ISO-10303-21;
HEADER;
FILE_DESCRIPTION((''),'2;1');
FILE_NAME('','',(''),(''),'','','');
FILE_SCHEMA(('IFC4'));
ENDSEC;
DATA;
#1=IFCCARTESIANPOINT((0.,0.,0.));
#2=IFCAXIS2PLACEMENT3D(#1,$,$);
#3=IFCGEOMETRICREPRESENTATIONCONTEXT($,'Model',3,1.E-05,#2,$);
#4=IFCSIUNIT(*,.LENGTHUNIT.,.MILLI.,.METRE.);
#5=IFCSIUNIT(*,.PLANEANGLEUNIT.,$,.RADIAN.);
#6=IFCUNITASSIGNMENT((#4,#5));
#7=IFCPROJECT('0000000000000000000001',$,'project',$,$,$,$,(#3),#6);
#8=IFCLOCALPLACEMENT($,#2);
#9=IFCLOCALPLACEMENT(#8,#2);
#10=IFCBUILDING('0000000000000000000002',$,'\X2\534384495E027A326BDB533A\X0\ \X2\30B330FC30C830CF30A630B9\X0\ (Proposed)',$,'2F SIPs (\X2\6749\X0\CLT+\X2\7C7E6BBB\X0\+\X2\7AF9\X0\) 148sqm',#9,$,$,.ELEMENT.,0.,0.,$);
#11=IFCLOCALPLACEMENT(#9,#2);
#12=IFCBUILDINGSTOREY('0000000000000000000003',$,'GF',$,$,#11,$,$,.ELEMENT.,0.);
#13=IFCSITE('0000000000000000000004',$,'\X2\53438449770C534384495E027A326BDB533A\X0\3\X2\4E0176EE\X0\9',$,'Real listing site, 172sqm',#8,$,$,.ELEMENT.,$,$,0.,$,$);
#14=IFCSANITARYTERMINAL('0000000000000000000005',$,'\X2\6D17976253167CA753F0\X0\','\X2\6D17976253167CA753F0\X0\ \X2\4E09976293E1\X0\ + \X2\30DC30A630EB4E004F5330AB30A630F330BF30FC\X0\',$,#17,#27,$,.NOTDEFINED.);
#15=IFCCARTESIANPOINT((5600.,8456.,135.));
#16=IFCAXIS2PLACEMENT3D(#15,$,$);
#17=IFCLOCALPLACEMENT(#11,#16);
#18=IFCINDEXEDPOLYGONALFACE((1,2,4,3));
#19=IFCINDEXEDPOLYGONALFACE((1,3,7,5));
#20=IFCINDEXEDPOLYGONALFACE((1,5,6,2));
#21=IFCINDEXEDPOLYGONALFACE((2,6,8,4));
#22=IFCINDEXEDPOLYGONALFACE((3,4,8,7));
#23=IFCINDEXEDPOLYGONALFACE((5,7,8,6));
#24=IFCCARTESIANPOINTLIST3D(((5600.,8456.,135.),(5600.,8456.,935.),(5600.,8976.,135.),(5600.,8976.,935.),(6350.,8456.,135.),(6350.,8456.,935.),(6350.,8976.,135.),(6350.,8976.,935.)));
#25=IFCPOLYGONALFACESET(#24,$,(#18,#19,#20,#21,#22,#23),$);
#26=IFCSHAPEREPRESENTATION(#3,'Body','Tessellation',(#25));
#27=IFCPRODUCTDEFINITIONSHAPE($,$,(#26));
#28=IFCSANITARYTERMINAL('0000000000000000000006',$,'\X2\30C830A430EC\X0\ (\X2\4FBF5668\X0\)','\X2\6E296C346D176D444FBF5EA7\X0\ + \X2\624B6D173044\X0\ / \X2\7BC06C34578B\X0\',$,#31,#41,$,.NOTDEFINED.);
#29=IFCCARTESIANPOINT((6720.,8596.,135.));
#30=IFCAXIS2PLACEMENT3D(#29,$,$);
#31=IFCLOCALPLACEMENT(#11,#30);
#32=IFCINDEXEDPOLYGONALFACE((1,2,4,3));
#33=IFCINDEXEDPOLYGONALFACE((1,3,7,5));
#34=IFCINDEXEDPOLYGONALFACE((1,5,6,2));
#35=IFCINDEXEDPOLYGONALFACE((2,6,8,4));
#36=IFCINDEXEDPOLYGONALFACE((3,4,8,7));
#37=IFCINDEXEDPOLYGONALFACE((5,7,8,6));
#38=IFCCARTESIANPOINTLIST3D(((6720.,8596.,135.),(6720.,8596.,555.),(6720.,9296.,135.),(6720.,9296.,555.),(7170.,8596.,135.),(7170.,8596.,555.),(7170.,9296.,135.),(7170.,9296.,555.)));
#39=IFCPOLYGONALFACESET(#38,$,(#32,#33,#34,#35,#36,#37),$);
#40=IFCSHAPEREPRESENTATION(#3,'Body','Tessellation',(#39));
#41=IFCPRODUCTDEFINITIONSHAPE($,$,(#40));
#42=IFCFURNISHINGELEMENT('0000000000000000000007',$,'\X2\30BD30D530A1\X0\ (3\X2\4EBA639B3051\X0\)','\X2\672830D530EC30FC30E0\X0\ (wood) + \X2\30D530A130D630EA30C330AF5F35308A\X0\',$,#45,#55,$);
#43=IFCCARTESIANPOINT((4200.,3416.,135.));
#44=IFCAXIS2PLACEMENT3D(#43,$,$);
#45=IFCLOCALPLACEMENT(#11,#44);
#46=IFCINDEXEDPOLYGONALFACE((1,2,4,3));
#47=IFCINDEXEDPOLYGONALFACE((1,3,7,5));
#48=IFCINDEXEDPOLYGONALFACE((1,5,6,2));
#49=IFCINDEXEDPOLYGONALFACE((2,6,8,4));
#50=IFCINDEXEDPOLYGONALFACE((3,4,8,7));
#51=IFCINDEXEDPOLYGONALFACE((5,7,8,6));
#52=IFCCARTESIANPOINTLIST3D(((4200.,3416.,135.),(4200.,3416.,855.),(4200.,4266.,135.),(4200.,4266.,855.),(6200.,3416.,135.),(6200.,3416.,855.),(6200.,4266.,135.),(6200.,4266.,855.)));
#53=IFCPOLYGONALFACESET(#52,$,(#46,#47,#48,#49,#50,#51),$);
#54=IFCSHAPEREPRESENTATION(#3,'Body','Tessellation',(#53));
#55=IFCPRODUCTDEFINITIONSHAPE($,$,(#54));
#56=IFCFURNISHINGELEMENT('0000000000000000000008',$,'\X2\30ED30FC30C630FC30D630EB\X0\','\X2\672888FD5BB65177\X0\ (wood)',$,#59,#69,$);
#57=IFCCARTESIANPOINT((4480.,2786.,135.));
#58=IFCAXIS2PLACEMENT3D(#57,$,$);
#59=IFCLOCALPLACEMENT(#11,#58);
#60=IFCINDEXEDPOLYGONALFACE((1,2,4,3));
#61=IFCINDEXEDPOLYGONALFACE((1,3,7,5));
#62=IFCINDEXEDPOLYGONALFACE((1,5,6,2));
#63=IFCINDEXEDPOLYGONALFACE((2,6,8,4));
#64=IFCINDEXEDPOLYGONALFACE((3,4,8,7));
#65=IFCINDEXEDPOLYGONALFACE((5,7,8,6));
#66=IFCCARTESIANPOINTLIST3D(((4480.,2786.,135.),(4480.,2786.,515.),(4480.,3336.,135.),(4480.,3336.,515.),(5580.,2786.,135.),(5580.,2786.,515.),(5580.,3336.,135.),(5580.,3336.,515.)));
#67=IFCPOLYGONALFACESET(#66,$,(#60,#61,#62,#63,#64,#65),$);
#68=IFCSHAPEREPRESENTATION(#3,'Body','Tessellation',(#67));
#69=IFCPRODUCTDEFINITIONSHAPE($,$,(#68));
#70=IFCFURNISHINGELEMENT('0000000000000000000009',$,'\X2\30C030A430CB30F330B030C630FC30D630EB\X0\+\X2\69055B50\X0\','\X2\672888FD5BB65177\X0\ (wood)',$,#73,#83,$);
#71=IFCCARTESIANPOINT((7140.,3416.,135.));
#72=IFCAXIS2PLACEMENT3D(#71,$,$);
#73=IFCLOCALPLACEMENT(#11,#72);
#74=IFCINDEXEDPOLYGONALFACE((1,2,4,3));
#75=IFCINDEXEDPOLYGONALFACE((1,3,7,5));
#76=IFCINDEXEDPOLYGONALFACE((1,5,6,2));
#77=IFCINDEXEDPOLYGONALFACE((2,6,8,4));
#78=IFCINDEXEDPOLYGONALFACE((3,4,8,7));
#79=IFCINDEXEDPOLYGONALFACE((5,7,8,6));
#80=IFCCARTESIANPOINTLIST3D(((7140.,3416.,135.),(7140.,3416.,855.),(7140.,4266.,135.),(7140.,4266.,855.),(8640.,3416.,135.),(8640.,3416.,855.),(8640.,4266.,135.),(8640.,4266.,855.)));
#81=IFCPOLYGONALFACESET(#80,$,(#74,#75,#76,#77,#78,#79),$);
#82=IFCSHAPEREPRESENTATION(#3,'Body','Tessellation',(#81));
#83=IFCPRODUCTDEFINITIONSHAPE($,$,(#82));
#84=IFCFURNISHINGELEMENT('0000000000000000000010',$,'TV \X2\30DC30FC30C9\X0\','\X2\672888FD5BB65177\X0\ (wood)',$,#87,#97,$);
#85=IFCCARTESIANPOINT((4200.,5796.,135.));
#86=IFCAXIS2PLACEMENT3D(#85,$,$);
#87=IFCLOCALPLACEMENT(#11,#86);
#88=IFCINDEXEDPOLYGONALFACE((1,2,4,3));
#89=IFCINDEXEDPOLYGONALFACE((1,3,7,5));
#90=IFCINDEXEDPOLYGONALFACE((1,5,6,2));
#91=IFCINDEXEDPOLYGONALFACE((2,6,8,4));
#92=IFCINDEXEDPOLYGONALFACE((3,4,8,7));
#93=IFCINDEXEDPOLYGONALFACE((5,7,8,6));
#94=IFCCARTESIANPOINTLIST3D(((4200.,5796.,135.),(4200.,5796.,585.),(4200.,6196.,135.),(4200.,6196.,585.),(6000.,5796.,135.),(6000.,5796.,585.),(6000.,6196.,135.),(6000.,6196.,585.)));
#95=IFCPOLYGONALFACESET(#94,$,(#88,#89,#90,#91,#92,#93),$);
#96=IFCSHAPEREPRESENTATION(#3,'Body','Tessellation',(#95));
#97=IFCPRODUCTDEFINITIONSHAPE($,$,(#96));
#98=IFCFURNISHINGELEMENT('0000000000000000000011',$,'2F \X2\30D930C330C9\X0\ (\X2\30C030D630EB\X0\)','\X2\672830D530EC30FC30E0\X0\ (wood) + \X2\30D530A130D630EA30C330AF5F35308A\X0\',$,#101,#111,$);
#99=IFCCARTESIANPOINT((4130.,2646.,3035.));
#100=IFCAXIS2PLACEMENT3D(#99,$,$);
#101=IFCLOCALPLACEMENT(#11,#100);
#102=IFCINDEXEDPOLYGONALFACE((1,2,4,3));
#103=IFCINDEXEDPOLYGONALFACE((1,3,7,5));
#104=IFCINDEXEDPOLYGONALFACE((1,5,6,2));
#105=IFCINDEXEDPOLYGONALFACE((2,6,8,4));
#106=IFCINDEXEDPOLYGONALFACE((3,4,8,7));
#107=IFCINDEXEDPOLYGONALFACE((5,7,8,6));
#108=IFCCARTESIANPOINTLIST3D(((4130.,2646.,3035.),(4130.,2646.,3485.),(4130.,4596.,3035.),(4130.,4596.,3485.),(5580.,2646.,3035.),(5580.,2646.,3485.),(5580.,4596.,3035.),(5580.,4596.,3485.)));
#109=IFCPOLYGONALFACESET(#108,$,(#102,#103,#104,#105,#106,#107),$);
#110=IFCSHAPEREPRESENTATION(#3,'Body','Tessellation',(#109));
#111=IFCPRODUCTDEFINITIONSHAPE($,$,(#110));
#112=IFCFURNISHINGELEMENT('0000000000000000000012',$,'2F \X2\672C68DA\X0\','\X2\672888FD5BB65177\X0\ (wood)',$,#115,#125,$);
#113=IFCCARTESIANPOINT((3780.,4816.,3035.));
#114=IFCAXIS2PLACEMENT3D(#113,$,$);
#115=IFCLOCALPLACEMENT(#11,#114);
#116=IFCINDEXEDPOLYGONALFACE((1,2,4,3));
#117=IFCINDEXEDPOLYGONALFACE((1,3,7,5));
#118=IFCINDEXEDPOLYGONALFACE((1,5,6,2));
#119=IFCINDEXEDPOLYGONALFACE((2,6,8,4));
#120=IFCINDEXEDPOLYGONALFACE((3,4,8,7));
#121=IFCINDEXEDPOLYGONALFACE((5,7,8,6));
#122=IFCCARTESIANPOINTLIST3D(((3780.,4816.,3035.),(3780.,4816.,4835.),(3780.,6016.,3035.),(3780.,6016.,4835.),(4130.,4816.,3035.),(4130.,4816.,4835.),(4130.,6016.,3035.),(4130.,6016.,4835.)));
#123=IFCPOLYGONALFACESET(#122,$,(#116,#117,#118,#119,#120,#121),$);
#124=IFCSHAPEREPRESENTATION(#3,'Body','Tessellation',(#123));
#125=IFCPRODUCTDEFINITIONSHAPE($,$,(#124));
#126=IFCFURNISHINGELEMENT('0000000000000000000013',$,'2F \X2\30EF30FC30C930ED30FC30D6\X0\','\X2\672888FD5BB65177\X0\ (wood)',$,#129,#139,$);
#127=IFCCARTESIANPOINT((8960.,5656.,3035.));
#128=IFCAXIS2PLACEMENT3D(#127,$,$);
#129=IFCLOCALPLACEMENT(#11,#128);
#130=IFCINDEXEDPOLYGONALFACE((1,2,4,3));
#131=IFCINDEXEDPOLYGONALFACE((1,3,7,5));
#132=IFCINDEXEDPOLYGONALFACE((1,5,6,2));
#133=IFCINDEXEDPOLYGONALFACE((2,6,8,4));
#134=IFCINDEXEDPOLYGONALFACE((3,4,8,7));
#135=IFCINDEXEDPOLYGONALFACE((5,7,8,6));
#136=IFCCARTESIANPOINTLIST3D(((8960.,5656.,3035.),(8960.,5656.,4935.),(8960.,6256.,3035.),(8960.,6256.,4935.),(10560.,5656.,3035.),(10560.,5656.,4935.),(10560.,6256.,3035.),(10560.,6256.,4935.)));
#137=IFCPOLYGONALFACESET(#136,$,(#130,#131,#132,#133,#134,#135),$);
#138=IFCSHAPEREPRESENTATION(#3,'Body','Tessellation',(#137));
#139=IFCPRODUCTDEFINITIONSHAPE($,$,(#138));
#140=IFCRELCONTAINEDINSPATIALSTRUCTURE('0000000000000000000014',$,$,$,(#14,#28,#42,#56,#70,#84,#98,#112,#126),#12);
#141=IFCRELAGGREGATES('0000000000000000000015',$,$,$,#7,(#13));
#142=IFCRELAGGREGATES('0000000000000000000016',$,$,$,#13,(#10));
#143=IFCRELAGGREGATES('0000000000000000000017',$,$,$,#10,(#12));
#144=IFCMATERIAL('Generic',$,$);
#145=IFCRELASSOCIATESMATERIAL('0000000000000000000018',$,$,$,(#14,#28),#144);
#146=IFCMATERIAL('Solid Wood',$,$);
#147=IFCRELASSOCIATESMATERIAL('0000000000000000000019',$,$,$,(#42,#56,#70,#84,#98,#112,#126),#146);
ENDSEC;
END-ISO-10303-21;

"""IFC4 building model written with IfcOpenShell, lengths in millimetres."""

from ifc_helpers import new_model, si_unit, frame, frame_2d, origin, place, context, project, spatial, rectangle, extrude, material, element, save


model = new_model("IFC4")

# Units and contexts
model_context = context("Model", 3, precision=1e-05, world=origin())
ifc_project = project(units=[si_unit("LENGTHUNIT", "METRE", prefix="MILLI"), si_unit("PLANEANGLEUNIT", "RADIAN")], contexts=[model_context])

# Site, building, storey
site_placement = place(None, origin())
site = spatial("IfcSite", under=ifc_project, at=site_placement, Name="千葉県千葉市稲毛区3丁目9", ObjectType="Real listing site, 172sqm", CompositionType="ELEMENT", RefElevation=0.0)
building_placement = place(site_placement, origin())
building = spatial("IfcBuilding", under=site, at=building_placement, Name="千葉市稲毛区 コートハウス (Proposed)", ObjectType="2F SIPs (杉CLT+籾殻+竹) 148sqm", CompositionType="ELEMENT", ElevationOfRefHeight=0.0, ElevationOfTerrain=0.0)
storey_placement = place(building_placement, origin())
storey = spatial("IfcBuildingStorey", under=building, at=storey_placement, Name="GF", CompositionType="ELEMENT", Elevation=0.0)

# Shared definitions
ifc_material_1 = material(Name="Solid Wood")

# Shared definitions
ifc_material_2 = material(Name="Generic")

# Sanitary terminals
sanitary_terminal_1_placement = place(storey_placement, frame((5600.0, 8456.0, 135.0)))
element("IfcSanitaryTerminal", 1, at=sanitary_terminal_1_placement, inside=storey, material=ifc_material_2, Name="洗面化粧台", Description="洗面化粧台 三面鏡 + ボウル一体カウンター", PredefinedType="NOTDEFINED", context=model_context, shape_type="SweptSolid", body=[
    extrude(rectangle(XDim=750.0, YDim=520.0, at=frame_2d((375.0, 260.0))), frame((5600.0, 8456.0, 135.0)), (0.0, 0.0, 1.0), 800.0),
])
sanitary_terminal_2_placement = place(storey_placement, frame((6720.0, 8596.0, 135.0)))
element("IfcSanitaryTerminal", 2, at=sanitary_terminal_2_placement, inside=storey, material=ifc_material_2, Name="トイレ (便器)", Description="温水洗浄便座 + 手洗い / 節水型", PredefinedType="NOTDEFINED", context=model_context, shape_type="SweptSolid", body=[
    extrude(rectangle(XDim=450.0, YDim=700.0, at=frame_2d((225.0, 350.0))), frame((6720.0, 8596.0, 135.0)), (0.0, 0.0, 1.0), 420.0),
])

# Furnishing elements
furnishing_1_placement = place(storey_placement, frame((4200.0, 3416.0, 135.0)))
element("IfcFurnishingElement", 3, at=furnishing_1_placement, inside=storey, material=ifc_material_1, Name="ソファ (3人掛け)", Description="木フレーム (wood) + ファブリック張り", context=model_context, shape_type="SweptSolid", body=[
    extrude(rectangle(XDim=2000.0, YDim=850.0, at=frame_2d((1000.0, 425.0))), frame((4200.0, 3416.0, 135.0)), (0.0, 0.0, 1.0), 720.0),
])
furnishing_2_placement = place(storey_placement, frame((4480.0, 2786.0, 135.0)))
element("IfcFurnishingElement", 4, at=furnishing_2_placement, inside=storey, material=ifc_material_1, Name="ローテーブル", Description="木製家具 (wood)", context=model_context, shape_type="SweptSolid", body=[
    extrude(rectangle(XDim=1100.0, YDim=550.0, at=frame_2d((550.0, 275.0))), frame((4480.0, 2786.0, 135.0)), (0.0, 0.0, 1.0), 380.0),
])
furnishing_3_placement = place(storey_placement, frame((7140.0, 3416.0, 135.0)))
element("IfcFurnishingElement", 5, at=furnishing_3_placement, inside=storey, material=ifc_material_1, Name="ダイニングテーブル+椅子", Description="木製家具 (wood)", context=model_context, shape_type="SweptSolid", body=[
    extrude(rectangle(XDim=1500.0, YDim=850.0, at=frame_2d((750.0, 425.0))), frame((7140.0, 3416.0, 135.0)), (0.0, 0.0, 1.0), 720.0),
])
furnishing_4_placement = place(storey_placement, frame((4200.0, 5796.0, 135.0)))
element("IfcFurnishingElement", 6, at=furnishing_4_placement, inside=storey, material=ifc_material_1, Name="TV ボード", Description="木製家具 (wood)", context=model_context, shape_type="SweptSolid", body=[
    extrude(rectangle(XDim=1800.0, YDim=400.0, at=frame_2d((900.0, 200.0))), frame((4200.0, 5796.0, 135.0)), (0.0, 0.0, 1.0), 450.0),
])
furnishing_5_placement = place(storey_placement, frame((4130.0, 2646.0, 3035.0)))
element("IfcFurnishingElement", 7, at=furnishing_5_placement, inside=storey, material=ifc_material_1, Name="2F ベッド (ダブル)", Description="木フレーム (wood) + ファブリック張り", context=model_context, shape_type="SweptSolid", body=[
    extrude(rectangle(XDim=1450.0, YDim=1950.0, at=frame_2d((725.0, 975.0))), frame((4130.0, 2646.0, 3035.0)), (0.0, 0.0, 1.0), 450.0),
])
furnishing_6_placement = place(storey_placement, frame((3780.0, 4816.0, 3035.0)))
element("IfcFurnishingElement", 8, at=furnishing_6_placement, inside=storey, material=ifc_material_1, Name="2F 本棚", Description="木製家具 (wood)", context=model_context, shape_type="SweptSolid", body=[
    extrude(rectangle(XDim=350.0, YDim=1200.0, at=frame_2d((175.0, 600.0))), frame((3780.0, 4816.0, 3035.0)), (0.0, 0.0, 1.0), 1800.0),
])
furnishing_7_placement = place(storey_placement, frame((8960.0, 5656.0, 3035.0)))
element("IfcFurnishingElement", 9, at=furnishing_7_placement, inside=storey, material=ifc_material_1, Name="2F ワードローブ", Description="木製家具 (wood)", context=model_context, shape_type="SweptSolid", body=[
    extrude(rectangle(XDim=1600.0, YDim=600.0, at=frame_2d((800.0, 300.0))), frame((8960.0, 5656.0, 3035.0)), (0.0, 0.0, 1.0), 1900.0),
])

save(model, "model.ifc")
